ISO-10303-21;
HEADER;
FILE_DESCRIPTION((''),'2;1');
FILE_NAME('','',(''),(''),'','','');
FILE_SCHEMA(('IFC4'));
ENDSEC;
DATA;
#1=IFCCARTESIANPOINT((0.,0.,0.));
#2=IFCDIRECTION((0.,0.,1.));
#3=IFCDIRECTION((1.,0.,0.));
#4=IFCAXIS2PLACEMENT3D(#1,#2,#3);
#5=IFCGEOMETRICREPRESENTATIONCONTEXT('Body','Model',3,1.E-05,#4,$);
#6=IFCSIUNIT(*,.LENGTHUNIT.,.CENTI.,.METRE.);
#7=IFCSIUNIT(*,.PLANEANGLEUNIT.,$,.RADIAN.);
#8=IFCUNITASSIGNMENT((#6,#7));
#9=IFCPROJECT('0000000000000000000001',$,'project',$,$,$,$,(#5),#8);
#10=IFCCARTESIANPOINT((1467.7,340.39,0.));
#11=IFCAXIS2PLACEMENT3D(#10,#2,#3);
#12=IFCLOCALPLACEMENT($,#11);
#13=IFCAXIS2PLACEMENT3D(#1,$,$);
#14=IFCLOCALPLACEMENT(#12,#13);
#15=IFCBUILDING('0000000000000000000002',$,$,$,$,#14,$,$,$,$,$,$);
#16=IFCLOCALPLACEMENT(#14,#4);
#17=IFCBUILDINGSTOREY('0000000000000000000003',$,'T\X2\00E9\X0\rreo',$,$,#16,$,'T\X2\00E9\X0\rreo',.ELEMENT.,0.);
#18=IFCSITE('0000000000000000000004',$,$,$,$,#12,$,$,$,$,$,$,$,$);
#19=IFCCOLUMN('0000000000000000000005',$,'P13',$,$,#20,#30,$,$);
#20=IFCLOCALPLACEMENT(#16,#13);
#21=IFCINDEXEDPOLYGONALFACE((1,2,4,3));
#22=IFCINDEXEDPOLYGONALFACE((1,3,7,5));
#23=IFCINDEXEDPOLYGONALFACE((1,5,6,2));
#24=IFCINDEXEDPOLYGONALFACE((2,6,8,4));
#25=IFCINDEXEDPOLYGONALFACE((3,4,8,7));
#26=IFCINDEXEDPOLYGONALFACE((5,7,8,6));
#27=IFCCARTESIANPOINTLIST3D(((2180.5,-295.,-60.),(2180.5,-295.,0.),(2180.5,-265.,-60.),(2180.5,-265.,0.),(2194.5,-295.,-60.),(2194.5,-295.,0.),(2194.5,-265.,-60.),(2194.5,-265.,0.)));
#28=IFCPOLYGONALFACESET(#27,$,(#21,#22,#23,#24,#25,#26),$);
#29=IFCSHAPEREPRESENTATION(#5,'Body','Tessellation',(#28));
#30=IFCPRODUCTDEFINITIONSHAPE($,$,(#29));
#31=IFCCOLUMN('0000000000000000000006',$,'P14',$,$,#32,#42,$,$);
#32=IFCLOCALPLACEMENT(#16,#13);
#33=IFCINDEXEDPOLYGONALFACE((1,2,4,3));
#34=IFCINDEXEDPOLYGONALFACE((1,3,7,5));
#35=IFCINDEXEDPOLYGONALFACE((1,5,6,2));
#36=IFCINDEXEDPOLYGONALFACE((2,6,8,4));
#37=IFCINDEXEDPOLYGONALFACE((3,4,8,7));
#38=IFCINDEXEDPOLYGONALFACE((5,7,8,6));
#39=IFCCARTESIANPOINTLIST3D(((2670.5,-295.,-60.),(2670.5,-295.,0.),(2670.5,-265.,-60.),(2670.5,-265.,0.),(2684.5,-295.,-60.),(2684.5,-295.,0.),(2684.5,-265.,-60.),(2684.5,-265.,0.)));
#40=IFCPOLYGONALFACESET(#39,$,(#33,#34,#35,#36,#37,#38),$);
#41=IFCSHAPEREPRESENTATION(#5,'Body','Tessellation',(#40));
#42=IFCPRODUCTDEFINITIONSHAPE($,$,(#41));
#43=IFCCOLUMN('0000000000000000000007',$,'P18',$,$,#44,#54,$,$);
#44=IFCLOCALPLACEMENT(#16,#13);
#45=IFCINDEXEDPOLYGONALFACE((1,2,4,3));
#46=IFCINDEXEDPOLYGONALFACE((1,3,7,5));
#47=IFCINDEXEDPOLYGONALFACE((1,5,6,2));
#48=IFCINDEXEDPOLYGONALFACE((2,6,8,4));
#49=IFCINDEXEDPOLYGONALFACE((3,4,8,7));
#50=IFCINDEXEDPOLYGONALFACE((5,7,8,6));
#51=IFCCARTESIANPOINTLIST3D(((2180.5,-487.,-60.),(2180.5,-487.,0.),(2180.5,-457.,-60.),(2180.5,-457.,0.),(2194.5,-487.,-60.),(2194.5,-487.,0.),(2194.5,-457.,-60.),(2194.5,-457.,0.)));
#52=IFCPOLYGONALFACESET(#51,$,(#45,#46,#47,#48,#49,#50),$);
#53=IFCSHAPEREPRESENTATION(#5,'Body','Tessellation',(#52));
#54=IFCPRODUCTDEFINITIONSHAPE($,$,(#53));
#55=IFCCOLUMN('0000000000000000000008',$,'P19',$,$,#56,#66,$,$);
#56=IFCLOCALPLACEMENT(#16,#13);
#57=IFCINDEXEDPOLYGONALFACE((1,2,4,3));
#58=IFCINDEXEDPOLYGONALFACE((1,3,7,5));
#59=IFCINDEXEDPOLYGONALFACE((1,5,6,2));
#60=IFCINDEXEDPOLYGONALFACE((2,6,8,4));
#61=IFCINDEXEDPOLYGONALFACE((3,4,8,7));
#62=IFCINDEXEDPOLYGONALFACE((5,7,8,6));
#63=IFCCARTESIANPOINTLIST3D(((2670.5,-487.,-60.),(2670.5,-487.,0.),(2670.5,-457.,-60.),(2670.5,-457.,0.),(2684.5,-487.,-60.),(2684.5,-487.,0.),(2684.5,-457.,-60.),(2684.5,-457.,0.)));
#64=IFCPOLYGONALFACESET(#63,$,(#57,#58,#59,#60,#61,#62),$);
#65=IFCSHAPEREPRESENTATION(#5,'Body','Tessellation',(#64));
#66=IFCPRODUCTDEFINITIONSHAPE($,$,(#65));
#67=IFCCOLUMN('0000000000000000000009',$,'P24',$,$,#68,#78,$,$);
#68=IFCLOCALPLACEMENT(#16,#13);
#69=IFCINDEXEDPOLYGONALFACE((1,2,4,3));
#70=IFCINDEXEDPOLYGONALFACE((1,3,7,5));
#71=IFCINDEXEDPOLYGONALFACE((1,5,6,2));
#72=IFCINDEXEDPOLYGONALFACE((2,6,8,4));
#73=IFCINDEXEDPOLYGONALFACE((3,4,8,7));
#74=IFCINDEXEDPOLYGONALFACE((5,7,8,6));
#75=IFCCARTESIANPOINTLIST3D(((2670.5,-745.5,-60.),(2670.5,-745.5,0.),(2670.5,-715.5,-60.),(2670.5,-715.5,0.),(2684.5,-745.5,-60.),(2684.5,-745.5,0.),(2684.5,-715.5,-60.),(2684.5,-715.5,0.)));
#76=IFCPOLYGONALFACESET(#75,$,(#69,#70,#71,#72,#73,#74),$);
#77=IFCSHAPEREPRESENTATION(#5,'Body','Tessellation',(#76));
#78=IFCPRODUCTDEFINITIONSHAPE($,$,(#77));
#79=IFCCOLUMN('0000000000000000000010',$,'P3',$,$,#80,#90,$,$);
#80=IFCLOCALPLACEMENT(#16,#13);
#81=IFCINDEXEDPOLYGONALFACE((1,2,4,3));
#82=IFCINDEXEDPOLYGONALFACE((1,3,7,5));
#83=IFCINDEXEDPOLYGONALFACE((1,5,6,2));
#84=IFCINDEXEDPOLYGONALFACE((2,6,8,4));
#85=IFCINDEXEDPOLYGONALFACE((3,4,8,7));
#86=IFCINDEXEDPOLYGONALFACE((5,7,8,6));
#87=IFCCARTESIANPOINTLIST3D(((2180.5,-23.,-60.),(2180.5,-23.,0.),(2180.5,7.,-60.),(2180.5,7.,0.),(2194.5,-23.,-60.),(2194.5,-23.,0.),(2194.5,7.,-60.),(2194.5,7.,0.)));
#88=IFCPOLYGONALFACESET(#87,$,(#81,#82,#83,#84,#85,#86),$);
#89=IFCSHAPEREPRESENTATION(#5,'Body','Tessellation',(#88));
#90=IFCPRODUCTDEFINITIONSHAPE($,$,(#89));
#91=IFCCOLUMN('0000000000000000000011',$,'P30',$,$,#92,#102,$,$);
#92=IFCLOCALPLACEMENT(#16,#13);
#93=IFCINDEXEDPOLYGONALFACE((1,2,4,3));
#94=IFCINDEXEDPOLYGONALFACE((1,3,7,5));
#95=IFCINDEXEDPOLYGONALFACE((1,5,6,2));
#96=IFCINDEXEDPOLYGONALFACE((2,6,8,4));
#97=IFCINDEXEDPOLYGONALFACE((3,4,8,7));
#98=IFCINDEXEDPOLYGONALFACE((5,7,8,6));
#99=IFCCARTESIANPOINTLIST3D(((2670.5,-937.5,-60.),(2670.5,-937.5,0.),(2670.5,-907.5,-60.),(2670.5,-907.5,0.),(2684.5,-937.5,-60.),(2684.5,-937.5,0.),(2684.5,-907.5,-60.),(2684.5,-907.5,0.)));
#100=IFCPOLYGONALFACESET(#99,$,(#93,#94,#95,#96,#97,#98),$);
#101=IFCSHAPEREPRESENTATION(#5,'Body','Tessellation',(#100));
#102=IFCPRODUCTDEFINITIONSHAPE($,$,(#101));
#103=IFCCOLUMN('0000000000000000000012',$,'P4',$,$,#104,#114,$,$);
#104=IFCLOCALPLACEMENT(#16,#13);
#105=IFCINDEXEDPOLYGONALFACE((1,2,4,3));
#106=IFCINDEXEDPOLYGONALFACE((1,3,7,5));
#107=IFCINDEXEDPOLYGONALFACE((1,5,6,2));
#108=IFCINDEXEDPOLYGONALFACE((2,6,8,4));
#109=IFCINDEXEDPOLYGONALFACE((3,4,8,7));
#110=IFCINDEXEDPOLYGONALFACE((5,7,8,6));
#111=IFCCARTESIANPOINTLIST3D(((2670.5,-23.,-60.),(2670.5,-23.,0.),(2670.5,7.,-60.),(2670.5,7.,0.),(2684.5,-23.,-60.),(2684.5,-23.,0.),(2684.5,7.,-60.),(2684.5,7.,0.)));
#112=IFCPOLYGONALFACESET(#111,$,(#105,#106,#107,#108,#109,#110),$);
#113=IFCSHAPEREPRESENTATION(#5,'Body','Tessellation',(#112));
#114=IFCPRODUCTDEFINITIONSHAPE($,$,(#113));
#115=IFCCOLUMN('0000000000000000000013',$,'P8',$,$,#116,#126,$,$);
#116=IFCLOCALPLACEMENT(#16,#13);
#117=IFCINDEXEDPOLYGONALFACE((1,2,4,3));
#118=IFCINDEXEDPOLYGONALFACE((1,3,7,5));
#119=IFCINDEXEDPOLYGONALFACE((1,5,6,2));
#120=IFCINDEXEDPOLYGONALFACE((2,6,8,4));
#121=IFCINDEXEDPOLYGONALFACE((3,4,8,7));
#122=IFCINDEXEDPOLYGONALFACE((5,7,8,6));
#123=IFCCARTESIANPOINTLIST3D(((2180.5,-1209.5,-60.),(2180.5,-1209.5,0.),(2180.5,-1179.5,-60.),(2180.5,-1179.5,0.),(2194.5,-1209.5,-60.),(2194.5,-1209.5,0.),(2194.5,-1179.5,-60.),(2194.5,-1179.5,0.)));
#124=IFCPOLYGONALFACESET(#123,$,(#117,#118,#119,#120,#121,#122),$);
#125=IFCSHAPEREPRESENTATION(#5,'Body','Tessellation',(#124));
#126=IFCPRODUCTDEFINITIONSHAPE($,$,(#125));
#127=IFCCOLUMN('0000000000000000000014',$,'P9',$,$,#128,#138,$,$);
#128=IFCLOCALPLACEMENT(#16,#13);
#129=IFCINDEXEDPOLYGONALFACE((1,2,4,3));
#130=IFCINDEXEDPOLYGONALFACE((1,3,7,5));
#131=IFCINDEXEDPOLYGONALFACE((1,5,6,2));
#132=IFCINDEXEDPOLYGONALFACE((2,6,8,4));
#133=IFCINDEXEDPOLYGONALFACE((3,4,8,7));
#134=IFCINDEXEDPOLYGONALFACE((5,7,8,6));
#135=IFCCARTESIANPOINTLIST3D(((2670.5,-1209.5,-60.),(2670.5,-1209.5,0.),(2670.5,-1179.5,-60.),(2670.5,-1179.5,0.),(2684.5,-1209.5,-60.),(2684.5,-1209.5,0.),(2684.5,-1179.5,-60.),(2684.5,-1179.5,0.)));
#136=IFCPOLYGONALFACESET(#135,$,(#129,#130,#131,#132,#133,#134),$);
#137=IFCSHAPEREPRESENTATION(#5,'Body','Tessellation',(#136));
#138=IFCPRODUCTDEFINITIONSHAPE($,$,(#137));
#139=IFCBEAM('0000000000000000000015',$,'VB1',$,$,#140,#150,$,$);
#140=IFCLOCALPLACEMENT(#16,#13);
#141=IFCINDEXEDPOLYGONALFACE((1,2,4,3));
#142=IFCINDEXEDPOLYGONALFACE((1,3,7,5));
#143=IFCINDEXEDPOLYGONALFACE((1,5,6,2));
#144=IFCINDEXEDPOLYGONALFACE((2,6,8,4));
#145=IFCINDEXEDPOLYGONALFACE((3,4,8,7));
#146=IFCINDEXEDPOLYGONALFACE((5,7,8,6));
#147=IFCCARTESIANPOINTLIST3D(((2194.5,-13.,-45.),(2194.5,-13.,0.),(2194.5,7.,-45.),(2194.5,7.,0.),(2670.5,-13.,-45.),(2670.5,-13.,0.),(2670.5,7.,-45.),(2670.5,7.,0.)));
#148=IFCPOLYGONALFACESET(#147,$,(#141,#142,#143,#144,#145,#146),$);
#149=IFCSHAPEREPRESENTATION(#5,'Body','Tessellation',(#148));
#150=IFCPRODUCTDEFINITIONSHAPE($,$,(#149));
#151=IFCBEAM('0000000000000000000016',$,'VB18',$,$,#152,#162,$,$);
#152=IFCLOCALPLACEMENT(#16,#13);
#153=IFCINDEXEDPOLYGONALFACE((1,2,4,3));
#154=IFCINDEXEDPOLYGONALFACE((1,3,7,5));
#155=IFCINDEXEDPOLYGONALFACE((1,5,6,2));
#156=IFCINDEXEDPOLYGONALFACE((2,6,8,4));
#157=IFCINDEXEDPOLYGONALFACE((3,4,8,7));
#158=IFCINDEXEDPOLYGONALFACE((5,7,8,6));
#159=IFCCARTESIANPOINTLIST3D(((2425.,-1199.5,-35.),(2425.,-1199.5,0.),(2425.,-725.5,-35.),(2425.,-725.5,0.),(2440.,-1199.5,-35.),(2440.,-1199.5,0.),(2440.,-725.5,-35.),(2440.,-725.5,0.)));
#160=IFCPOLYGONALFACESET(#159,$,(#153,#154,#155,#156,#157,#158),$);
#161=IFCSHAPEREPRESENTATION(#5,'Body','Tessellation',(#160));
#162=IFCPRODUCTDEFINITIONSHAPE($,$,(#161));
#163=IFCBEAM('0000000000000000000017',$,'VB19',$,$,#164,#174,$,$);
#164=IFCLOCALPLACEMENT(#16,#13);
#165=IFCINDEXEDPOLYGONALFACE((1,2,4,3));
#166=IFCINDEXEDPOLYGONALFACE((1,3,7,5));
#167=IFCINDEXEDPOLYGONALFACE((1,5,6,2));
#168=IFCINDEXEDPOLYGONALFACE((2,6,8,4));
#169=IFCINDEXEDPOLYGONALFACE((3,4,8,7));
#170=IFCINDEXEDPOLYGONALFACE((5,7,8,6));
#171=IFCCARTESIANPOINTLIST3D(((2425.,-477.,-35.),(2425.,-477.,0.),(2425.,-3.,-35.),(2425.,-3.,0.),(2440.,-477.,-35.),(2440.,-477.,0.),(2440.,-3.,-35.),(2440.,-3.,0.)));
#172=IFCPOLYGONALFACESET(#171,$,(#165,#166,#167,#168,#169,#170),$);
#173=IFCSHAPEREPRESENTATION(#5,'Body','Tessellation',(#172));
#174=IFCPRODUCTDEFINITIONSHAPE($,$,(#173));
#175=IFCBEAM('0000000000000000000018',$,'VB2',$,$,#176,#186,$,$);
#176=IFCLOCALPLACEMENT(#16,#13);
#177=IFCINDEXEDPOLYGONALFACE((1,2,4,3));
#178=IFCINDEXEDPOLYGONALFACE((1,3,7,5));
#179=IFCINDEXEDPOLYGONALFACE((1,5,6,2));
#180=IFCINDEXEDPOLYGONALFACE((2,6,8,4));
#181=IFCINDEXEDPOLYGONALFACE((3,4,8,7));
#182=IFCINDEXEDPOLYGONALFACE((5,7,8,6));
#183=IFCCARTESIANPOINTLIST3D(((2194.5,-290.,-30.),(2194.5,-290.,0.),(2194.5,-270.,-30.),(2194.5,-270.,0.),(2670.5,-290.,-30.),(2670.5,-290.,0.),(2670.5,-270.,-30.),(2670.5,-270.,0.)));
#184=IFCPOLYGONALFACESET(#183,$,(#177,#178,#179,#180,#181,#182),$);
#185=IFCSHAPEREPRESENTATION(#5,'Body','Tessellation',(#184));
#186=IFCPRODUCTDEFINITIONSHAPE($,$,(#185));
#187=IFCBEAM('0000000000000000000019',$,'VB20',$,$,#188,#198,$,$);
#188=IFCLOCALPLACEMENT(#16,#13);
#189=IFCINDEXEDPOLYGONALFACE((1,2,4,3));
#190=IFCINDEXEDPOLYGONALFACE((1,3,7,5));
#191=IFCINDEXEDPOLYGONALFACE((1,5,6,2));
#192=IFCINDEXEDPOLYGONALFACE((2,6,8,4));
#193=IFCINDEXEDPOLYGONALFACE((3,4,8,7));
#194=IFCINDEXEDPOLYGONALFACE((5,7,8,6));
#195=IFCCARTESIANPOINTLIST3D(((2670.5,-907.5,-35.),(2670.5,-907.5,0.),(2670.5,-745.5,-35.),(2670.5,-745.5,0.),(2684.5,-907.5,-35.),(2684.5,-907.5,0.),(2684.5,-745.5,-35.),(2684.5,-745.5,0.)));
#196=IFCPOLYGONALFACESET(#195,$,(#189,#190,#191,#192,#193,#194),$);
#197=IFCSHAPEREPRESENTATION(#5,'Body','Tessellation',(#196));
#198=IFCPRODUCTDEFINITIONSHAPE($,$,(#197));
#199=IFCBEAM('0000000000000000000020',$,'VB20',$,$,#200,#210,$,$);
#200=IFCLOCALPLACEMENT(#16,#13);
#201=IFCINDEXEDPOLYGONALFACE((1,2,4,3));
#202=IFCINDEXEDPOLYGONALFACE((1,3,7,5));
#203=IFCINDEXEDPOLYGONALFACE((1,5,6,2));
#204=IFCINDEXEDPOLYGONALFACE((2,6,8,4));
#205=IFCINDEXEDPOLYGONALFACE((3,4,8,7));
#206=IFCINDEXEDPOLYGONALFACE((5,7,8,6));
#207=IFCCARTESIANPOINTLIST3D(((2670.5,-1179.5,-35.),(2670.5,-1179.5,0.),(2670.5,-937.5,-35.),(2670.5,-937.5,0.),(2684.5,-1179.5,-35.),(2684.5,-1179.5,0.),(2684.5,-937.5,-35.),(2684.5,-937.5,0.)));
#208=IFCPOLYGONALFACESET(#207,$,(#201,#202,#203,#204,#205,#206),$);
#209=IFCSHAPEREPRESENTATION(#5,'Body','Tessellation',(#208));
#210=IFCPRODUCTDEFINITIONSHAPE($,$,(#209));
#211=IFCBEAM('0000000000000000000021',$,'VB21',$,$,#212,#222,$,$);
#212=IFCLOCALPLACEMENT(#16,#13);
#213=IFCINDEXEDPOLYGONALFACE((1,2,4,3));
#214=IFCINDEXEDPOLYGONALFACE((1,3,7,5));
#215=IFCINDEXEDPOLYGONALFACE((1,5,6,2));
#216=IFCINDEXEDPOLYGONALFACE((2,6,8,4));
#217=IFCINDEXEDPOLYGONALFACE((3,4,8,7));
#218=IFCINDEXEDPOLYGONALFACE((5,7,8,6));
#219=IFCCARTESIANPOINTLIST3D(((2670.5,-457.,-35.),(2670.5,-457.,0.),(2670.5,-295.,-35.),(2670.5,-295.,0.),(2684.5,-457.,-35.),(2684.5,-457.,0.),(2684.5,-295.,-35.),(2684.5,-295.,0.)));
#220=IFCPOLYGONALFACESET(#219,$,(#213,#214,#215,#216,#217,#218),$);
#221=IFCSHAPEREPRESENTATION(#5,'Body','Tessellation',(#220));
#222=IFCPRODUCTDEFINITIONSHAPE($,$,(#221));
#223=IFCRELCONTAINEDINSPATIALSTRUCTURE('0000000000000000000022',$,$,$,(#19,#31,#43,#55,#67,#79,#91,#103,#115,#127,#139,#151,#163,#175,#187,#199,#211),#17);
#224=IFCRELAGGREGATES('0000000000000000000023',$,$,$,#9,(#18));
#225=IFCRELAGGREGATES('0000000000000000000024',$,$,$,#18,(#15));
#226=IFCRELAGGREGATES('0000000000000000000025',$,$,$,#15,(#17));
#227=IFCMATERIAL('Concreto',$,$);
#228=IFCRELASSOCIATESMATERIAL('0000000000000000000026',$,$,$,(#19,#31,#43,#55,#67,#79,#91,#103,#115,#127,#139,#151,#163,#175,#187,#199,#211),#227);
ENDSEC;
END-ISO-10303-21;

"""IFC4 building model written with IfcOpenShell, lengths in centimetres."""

from ifc_helpers import new_model, si_unit, frame, origin, origin_with_axes, origin_2d_with_axis, place, context, project, spatial, rectangle, extrude, material, element, save


model = new_model("IFC4")

# Units and contexts
model_context = context("Model", 3, precision=1e-05, world=origin_with_axes(), identifier="Body")
ifc_project = project(units=[si_unit("LENGTHUNIT", "METRE", prefix="CENTI"), si_unit("PLANEANGLEUNIT", "RADIAN")], contexts=[model_context])

# Site, building, storey
site_placement = place(None, frame((1467.7, 340.39, 0.0), z_axis=(0.0, 0.0, 1.0), x_axis=(1.0, 0.0, 0.0)))
site = spatial("IfcSite", under=ifc_project, at=site_placement)
building_placement = place(site_placement, origin())
building = spatial("IfcBuilding", under=site, at=building_placement)
storey_placement = place(building_placement, origin_with_axes())
storey = spatial("IfcBuildingStorey", under=building, at=storey_placement, Name="Térreo", LongName="Térreo", CompositionType="ELEMENT", Elevation=0.0)

# Columns
ifc_material = material(Name="Concreto")
for number, where, z_axis, x_axis, name in (
    (1, (2187.5, -280.0, 0.0), (0.0, 0.0, 1.0), (1.0, 0.0, 0.0), "P13"),
    (2, (2677.5, -280.0, 0.0), (0.0, 0.0, 1.0), (1.0, 0.0, 0.0), "P14"),
):
    element("IfcColumn", number, at=place(storey_placement, frame(where, z_axis=z_axis, x_axis=x_axis)), inside=storey, material=ifc_material, Name=name, context=model_context, shape_type="SolidModel", body=[
        extrude(rectangle(XDim=14.0, YDim=30.0, at=origin_2d_with_axis()), frame((0.0, 0.0, -60.0), z_axis=(0.0, 0.0, 1.0), x_axis=(1.0, 0.0, 0.0)), (0.0, 0.0, 1.0), 60.0),
    ])
for number, where, z_axis, x_axis, name in (
    (3, (2187.5, -472.0, 0.0), (0.0, 0.0, 1.0), (1.0, 0.0, 0.0), "P18"),
    (4, (2677.5, -472.0, 0.0), (0.0, 0.0, 1.0), (1.0, 0.0, 0.0), "P19"),
):
    element("IfcColumn", number, at=place(storey_placement, frame(where, z_axis=z_axis, x_axis=x_axis)), inside=storey, material=ifc_material, Name=name, context=model_context, shape_type="SolidModel", body=[
        extrude(rectangle(XDim=14.0, YDim=30.0, at=origin_2d_with_axis()), frame((0.0, 0.0, -60.0), z_axis=(0.0, 0.0, 1.0), x_axis=(-1.0, 0.0, 0.0)), (0.0, 0.0, 1.0), 60.0),
    ])
for number, where, z_axis, x_axis, name in (
    (5, (2677.5, -730.5, 0.0), (0.0, 0.0, 1.0), (1.0, 0.0, 0.0), "P24"),
    (6, (2187.5, -8.0, 0.0), (0.0, 0.0, 1.0), (1.0, 0.0, 0.0), "P3"),
    (7, (2677.5, -922.5, 0.0), (0.0, 0.0, 1.0), (1.0, 0.0, 0.0), "P30"),
    (8, (2677.5, -8.0, 0.0), (0.0, 0.0, 1.0), (1.0, 0.0, 0.0), "P4"),
    (9, (2187.5, -1194.5, 0.0), (0.0, 0.0, 1.0), (1.0, 0.0, 0.0), "P8"),
    (10, (2677.5, -1194.5, 0.0), (0.0, 0.0, 1.0), (1.0, 0.0, 0.0), "P9"),
):
    element("IfcColumn", number, at=place(storey_placement, frame(where, z_axis=z_axis, x_axis=x_axis)), inside=storey, material=ifc_material, Name=name, context=model_context, shape_type="SolidModel", body=[
        extrude(rectangle(XDim=14.0, YDim=30.0, at=origin_2d_with_axis()), frame((0.0, 0.0, -60.0), z_axis=(0.0, 0.0, 1.0), x_axis=(1.0, 0.0, 0.0)), (0.0, 0.0, 1.0), 60.0),
    ])

# Beams
beam_1_placement = place(storey_placement, frame((2432.5, -3.0, 0.0), z_axis=(0.0, 0.0, 1.0), x_axis=(1.0, 0.0, 0.0)))
element("IfcBeam", 11, at=beam_1_placement, inside=storey, material=ifc_material, Name="VB1", context=model_context, shape_type="SolidModel", body=[
    extrude(rectangle(XDim=20.0, YDim=45.0, at=origin_2d_with_axis()), frame((-238.0, 0.0, -22.5), z_axis=(1.0, 0.0, 0.0), x_axis=(0.0, 1.0, 0.0)), (0.0, 0.0, 1.0), 476.0),
])
for number, where, z_axis, x_axis, name in (
    (12, (2432.5, -962.5, 0.0), (0.0, 0.0, 1.0), (1.0, 0.0, 0.0), "VB18"),
    (13, (2432.5, -240.0, 0.0), (0.0, 0.0, 1.0), (1.0, 0.0, 0.0), "VB19"),
):
    element("IfcBeam", number, at=place(storey_placement, frame(where, z_axis=z_axis, x_axis=x_axis)), inside=storey, material=ifc_material, Name=name, context=model_context, shape_type="SolidModel", body=[
        extrude(rectangle(XDim=15.0, YDim=35.0, at=origin_2d_with_axis()), frame((0.0, -237.0, -17.5), z_axis=(0.0, 1.0, 0.0), x_axis=(1.0, 0.0, 0.0)), (0.0, 0.0, 1.0), 474.0),
    ])
beam_2_placement = place(storey_placement, frame((2432.5, -280.0, 0.0), z_axis=(0.0, 0.0, 1.0), x_axis=(1.0, 0.0, 0.0)))
element("IfcBeam", 14, at=beam_2_placement, inside=storey, material=ifc_material, Name="VB2", context=model_context, shape_type="SolidModel", body=[
    extrude(rectangle(XDim=20.0, YDim=30.0, at=origin_2d_with_axis()), frame((-238.0, 0.0, -15.0), z_axis=(1.0, 0.0, 0.0), x_axis=(0.0, 1.0, 0.0)), (0.0, 0.0, 1.0), 476.0),
])
beam_3_placement = place(storey_placement, frame((2677.5, -826.5, 0.0), z_axis=(0.0, 0.0, 1.0), x_axis=(1.0, 0.0, 0.0)))
element("IfcBeam", 15, at=beam_3_placement, inside=storey, material=ifc_material, Name="VB20", context=model_context, shape_type="SolidModel", body=[
    extrude(rectangle(XDim=14.0, YDim=35.0, at=origin_2d_with_axis()), frame((0.0, -81.0, -17.5), z_axis=(0.0, 1.0, 0.0), x_axis=(1.0, 0.0, 0.0)), (0.0, 0.0, 1.0), 162.0),
])
beam_4_placement = place(storey_placement, frame((2677.5, -1058.5, 0.0), z_axis=(0.0, 0.0, 1.0), x_axis=(1.0, 0.0, 0.0)))
element("IfcBeam", 16, at=beam_4_placement, inside=storey, material=ifc_material, Name="VB20", context=model_context, shape_type="SolidModel", body=[
    extrude(rectangle(XDim=14.0, YDim=35.0, at=origin_2d_with_axis()), frame((0.0, -121.0, -17.5), z_axis=(0.0, 1.0, 0.0), x_axis=(1.0, 0.0, 0.0)), (0.0, 0.0, 1.0), 242.0),
])
beam_5_placement = place(storey_placement, frame((2677.5, -376.0, 0.0), z_axis=(0.0, 0.0, 1.0), x_axis=(1.0, 0.0, 0.0)))
element("IfcBeam", 17, at=beam_5_placement, inside=storey, material=ifc_material, Name="VB21", context=model_context, shape_type="SolidModel", body=[
    extrude(rectangle(XDim=14.0, YDim=35.0, at=origin_2d_with_axis()), frame((0.0, -81.0, -17.5), z_axis=(0.0, 1.0, 0.0), x_axis=(1.0, 0.0, 0.0)), (0.0, 0.0, 1.0), 162.0),
])

save(model, "model.ifc")
